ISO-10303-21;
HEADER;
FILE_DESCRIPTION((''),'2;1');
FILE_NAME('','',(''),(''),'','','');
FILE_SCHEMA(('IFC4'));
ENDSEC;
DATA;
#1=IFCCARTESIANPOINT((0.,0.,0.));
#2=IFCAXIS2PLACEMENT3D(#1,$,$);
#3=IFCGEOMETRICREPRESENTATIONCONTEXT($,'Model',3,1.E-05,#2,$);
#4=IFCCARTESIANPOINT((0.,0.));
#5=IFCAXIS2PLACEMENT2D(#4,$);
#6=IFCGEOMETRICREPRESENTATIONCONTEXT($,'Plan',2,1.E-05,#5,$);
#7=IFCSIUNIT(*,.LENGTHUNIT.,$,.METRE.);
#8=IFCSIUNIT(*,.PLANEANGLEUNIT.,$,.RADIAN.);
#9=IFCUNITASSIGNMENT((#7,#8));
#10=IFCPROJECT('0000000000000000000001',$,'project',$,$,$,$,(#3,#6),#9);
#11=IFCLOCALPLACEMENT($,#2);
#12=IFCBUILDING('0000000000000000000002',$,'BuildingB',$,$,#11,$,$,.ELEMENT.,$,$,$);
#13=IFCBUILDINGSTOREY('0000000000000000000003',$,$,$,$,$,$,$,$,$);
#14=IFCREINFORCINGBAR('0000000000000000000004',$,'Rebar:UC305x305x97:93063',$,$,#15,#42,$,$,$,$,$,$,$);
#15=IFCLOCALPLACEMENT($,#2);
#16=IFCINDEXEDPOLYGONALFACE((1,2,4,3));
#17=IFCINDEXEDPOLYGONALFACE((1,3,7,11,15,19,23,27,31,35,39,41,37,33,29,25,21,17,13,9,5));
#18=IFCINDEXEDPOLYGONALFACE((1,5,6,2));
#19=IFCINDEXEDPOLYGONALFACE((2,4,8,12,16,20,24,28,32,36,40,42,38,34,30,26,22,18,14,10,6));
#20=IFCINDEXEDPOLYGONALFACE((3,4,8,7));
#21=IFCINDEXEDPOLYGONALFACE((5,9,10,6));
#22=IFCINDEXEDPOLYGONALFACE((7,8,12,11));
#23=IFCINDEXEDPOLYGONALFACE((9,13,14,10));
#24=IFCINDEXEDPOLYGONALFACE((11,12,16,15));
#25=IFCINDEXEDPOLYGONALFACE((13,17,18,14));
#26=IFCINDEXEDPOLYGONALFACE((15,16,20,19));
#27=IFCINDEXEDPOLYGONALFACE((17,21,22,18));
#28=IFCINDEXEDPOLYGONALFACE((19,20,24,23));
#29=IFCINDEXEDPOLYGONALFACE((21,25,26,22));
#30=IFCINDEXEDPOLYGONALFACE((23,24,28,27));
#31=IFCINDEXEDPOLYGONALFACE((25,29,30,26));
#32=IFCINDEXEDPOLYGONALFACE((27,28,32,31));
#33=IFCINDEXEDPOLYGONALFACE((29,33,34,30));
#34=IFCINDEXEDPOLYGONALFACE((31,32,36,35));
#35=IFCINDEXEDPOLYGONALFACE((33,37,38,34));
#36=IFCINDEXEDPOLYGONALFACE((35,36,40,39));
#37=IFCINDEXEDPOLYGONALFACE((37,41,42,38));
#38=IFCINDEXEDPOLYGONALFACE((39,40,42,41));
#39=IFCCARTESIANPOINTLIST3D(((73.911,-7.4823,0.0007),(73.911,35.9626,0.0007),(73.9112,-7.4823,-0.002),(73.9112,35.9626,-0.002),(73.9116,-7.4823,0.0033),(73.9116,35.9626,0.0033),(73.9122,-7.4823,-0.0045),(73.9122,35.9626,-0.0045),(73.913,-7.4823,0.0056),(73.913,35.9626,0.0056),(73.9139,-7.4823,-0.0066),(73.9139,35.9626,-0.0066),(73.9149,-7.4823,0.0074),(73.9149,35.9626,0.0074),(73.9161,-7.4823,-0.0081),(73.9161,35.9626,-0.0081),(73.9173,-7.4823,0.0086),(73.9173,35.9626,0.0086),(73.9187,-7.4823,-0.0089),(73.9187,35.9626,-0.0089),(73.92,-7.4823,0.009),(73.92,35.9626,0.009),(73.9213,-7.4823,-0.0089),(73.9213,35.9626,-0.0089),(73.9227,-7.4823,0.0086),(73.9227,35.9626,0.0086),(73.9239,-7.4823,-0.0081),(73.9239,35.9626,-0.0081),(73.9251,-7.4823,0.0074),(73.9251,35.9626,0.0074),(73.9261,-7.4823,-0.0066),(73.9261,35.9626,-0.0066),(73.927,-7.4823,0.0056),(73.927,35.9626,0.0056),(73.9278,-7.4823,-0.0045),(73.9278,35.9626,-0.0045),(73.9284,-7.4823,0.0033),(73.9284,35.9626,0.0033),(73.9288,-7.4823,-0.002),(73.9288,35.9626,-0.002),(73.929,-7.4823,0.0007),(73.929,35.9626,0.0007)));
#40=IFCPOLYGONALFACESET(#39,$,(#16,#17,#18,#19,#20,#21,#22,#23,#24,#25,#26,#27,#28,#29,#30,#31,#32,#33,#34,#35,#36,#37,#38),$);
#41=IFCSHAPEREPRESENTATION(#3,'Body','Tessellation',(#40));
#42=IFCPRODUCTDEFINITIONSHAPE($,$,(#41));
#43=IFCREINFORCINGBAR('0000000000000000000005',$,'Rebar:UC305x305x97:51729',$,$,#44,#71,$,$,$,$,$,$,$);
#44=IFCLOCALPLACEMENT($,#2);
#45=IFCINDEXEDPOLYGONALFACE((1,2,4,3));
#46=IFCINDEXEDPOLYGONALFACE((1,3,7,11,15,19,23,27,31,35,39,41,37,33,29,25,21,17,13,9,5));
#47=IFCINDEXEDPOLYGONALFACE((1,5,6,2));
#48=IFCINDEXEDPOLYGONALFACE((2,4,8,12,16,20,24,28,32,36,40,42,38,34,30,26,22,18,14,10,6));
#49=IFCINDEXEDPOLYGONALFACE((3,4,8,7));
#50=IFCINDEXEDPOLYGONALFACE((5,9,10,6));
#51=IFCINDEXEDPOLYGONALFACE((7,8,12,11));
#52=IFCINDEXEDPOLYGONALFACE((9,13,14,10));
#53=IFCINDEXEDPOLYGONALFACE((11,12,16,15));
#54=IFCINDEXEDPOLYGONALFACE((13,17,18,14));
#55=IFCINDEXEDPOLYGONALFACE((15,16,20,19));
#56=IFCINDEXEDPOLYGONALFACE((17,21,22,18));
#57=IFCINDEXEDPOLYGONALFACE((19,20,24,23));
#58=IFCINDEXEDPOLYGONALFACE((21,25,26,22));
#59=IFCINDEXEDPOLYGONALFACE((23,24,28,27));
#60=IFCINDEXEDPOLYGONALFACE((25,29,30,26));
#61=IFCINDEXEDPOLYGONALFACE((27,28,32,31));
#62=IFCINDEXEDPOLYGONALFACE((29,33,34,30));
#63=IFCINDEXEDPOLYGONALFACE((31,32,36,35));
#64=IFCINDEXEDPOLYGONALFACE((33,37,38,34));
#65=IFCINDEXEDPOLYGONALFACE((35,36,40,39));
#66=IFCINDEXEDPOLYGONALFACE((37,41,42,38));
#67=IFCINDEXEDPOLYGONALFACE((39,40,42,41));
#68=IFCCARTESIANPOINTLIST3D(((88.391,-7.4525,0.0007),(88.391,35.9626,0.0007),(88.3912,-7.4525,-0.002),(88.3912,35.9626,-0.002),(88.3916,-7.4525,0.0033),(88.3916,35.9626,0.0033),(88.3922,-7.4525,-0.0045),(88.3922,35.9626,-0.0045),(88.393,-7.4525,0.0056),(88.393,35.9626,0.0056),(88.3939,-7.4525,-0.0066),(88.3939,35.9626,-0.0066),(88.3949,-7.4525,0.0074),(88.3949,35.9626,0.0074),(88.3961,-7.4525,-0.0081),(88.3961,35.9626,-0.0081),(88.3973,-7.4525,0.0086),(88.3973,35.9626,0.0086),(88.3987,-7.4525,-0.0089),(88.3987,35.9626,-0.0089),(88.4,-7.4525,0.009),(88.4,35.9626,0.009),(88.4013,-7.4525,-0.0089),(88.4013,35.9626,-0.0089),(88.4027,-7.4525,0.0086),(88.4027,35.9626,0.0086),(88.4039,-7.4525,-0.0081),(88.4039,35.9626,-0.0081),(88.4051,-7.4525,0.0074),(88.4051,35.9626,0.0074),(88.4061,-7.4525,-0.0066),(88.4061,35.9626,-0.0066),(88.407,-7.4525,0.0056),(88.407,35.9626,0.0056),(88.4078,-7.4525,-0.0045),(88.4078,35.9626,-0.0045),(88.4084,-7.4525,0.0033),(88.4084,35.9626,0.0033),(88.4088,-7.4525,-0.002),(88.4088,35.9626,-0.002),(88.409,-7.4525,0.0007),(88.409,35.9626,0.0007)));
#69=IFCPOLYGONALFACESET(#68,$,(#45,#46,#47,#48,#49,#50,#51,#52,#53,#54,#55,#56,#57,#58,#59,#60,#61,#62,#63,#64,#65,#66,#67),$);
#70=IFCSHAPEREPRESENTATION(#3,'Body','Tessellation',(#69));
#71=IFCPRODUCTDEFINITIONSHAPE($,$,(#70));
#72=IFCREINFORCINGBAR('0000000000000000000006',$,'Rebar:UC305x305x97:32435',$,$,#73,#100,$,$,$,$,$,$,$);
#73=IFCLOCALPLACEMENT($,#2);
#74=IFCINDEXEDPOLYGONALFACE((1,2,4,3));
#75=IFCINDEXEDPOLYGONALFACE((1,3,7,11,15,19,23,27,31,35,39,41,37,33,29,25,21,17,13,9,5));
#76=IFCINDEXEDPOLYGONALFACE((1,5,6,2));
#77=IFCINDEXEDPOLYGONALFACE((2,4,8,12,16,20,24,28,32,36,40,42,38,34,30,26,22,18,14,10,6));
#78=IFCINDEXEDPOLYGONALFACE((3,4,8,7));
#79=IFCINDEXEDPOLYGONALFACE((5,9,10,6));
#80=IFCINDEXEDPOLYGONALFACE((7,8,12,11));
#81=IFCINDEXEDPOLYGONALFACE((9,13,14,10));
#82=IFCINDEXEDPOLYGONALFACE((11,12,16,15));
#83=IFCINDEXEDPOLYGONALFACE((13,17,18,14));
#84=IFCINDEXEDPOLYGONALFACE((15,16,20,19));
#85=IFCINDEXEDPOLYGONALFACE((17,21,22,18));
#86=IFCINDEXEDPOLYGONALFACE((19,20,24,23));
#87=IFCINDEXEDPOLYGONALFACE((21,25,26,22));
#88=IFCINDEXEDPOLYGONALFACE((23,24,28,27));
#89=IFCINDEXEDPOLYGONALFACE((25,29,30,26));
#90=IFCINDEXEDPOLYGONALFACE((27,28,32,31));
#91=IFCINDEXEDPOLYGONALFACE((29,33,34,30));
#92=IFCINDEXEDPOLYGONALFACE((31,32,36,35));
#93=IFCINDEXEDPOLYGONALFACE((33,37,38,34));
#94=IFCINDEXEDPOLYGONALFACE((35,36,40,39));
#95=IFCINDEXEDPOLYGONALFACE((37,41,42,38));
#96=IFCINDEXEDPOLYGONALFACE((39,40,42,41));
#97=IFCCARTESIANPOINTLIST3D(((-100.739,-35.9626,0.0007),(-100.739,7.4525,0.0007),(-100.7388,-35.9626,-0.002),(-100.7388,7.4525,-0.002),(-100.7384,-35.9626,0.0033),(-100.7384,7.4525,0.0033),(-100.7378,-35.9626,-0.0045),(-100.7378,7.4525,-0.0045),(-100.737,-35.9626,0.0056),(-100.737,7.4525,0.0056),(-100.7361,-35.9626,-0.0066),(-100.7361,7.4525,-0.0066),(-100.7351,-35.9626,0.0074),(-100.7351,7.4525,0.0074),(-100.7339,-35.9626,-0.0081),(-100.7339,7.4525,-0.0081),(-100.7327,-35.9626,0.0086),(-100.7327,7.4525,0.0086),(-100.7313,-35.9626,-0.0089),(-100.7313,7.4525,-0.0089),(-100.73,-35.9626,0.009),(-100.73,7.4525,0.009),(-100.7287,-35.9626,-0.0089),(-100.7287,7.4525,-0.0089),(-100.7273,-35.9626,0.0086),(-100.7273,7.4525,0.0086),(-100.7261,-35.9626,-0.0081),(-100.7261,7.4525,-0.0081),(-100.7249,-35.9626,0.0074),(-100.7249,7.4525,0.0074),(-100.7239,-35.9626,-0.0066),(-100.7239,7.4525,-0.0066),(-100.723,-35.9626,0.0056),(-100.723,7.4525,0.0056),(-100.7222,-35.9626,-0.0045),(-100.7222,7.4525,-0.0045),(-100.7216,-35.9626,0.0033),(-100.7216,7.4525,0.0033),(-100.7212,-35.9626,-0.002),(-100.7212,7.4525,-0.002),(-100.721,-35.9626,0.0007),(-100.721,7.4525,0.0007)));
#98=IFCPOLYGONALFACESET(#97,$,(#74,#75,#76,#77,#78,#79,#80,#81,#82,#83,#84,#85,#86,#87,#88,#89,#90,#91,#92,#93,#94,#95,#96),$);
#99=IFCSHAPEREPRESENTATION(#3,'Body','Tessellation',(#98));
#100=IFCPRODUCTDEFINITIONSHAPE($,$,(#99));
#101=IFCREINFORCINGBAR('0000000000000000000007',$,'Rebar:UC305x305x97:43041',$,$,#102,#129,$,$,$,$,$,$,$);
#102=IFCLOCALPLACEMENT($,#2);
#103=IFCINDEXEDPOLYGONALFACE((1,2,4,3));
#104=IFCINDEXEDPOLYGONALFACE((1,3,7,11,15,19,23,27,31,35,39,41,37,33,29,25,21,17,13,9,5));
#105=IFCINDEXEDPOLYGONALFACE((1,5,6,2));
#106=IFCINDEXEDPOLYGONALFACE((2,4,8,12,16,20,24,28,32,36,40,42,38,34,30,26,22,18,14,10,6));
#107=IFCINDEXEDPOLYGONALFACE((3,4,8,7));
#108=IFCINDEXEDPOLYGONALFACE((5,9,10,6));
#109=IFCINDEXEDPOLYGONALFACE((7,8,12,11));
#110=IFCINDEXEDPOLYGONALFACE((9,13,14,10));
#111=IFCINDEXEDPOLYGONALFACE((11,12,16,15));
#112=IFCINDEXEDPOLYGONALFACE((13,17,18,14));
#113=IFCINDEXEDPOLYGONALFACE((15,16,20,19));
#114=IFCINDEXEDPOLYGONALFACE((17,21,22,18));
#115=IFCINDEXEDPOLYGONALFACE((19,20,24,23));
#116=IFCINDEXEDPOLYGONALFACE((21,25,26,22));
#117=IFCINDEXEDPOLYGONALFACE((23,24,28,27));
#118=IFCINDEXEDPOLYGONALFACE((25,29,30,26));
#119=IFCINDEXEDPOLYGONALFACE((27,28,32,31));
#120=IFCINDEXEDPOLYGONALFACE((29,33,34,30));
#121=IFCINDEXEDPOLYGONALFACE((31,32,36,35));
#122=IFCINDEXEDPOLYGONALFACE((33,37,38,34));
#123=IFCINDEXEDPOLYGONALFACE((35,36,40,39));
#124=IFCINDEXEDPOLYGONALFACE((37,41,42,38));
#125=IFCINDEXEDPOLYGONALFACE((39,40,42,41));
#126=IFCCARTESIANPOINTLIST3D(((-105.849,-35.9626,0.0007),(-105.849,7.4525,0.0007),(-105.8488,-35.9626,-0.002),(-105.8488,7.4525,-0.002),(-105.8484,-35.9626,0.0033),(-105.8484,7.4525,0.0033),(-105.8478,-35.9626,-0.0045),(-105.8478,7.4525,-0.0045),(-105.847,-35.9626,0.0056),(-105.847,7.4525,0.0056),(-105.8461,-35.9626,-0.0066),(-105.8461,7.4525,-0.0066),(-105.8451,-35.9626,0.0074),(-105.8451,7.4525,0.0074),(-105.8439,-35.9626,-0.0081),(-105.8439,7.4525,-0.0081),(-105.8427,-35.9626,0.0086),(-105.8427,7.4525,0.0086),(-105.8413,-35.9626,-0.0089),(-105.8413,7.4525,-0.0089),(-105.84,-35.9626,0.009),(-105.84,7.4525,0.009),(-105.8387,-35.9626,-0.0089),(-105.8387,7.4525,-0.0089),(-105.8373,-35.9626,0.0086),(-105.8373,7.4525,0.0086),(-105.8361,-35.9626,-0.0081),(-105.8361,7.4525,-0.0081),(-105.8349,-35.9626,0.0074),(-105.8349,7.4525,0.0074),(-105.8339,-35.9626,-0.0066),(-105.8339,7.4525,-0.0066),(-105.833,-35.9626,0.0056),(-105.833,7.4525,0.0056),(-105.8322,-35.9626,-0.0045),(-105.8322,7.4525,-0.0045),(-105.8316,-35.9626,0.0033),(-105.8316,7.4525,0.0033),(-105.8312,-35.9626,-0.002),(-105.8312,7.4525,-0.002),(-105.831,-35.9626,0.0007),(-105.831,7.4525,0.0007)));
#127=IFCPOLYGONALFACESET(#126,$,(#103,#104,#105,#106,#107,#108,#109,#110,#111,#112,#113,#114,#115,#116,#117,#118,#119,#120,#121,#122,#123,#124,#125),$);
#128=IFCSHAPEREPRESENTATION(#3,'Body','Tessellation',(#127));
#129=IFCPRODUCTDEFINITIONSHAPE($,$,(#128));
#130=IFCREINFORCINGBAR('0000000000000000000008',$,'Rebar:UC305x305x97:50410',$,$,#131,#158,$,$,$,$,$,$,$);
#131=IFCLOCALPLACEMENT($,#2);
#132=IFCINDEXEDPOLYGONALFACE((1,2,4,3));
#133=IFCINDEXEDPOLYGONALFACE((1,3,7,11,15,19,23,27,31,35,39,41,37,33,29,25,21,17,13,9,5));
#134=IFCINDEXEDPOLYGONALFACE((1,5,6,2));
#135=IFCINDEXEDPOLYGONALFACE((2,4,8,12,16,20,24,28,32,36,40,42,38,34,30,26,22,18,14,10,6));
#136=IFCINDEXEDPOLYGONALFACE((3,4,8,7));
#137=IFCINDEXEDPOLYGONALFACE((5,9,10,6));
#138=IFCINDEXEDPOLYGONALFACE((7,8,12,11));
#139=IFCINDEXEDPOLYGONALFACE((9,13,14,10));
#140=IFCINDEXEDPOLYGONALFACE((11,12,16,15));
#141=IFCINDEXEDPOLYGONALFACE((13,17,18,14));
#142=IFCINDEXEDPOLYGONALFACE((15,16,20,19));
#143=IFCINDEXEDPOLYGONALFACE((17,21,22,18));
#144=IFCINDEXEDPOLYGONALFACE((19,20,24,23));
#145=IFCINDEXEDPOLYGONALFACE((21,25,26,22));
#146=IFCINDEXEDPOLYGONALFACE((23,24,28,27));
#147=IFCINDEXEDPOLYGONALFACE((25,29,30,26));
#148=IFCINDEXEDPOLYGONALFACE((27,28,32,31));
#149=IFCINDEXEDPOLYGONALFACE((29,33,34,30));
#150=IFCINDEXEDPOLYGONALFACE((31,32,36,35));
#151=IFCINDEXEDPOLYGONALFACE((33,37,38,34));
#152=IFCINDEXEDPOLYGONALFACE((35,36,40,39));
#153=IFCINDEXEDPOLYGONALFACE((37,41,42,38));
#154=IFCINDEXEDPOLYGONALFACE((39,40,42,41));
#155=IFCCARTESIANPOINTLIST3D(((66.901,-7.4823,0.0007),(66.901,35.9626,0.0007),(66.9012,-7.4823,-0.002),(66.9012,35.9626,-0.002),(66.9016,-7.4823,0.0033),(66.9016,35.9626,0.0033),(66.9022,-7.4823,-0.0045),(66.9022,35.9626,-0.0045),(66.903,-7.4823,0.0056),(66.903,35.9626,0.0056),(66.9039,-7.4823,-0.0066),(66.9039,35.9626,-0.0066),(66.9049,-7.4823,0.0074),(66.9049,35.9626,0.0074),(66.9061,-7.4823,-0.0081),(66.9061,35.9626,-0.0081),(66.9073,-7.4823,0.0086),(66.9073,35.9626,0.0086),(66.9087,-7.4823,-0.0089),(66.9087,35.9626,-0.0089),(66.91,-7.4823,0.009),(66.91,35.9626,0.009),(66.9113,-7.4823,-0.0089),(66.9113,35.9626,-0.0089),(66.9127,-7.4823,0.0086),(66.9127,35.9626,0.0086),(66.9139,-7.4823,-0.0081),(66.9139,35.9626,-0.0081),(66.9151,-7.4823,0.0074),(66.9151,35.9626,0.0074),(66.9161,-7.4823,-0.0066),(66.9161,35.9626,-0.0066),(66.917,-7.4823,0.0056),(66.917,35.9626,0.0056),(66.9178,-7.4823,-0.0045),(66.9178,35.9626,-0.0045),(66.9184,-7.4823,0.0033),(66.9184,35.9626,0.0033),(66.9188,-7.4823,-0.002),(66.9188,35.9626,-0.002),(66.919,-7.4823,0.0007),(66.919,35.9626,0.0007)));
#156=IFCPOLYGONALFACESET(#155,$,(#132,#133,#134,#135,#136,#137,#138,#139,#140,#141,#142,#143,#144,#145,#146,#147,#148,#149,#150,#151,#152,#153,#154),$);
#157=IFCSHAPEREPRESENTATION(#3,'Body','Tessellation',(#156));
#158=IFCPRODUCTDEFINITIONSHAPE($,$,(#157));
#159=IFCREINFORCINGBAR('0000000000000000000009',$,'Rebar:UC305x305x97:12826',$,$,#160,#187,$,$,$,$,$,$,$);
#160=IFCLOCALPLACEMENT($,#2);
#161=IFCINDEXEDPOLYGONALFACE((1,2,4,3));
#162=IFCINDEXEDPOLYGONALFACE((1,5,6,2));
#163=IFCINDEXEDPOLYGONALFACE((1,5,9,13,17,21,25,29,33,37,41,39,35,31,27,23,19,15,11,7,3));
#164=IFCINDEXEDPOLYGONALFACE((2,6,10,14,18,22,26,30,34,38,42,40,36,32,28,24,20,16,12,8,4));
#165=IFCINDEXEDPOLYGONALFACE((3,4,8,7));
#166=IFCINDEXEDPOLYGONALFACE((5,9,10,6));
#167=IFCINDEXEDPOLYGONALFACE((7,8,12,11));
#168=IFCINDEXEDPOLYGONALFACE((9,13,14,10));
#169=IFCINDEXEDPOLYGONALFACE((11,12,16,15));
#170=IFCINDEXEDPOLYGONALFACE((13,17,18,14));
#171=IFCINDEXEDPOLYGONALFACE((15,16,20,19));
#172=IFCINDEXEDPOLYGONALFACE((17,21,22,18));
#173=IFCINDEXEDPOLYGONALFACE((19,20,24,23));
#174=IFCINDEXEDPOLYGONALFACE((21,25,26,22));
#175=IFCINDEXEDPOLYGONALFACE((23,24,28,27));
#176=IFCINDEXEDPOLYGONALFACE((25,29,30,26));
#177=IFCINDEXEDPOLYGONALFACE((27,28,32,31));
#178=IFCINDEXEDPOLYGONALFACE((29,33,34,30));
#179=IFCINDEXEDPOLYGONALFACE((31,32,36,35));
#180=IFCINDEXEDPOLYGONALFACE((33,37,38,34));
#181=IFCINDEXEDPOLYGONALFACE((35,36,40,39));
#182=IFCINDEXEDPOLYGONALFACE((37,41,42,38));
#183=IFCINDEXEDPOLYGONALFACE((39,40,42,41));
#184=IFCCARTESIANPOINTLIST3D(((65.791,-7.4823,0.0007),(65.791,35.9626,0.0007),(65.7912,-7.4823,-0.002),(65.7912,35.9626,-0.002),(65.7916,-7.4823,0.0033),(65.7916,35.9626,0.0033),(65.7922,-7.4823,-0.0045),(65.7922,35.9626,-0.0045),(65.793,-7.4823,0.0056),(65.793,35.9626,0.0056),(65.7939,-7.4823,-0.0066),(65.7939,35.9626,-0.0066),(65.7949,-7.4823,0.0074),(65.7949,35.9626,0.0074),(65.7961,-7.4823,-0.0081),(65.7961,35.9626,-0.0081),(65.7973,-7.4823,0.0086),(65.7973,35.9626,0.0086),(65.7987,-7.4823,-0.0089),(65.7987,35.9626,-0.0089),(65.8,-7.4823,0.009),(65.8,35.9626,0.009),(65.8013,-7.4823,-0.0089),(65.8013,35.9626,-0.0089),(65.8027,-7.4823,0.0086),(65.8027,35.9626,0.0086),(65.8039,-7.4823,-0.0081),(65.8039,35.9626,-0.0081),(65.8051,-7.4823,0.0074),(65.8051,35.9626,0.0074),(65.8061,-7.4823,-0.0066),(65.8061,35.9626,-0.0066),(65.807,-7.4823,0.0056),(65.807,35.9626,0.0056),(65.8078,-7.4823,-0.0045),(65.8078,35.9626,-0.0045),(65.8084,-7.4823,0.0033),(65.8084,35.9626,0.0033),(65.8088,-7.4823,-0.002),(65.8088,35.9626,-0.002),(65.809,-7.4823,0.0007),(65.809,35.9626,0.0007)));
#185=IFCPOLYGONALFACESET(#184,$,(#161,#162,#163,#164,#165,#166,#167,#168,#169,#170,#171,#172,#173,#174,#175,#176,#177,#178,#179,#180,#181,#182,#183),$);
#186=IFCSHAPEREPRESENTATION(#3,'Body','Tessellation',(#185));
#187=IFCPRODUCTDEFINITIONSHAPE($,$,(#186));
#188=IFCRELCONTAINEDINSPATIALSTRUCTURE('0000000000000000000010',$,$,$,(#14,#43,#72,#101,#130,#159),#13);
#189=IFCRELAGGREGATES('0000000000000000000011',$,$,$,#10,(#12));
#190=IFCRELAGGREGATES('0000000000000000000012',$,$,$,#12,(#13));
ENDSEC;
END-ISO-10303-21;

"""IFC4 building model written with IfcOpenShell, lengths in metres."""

from ifc_helpers import new_model, entity, si_unit, origin, origin_2d, place, context, project, spatial, element, save


model = new_model("IFC4")

# Units and contexts
model_context = context("Model", 3, precision=1e-05, world=origin())
plan_context = context("Plan", 2, precision=1e-05, world=origin_2d())
ifc_project = project(units=[si_unit("LENGTHUNIT", "METRE"), si_unit("PLANEANGLEUNIT", "RADIAN")], contexts=[model_context, plan_context])

# Building, storey
building_placement = place(None, origin())
building = spatial("IfcBuilding", under=ifc_project, at=building_placement, Name="BuildingB", CompositionType="ELEMENT")
storey = spatial("IfcBuildingStorey", under=building)

# Reinforcing bars
element("IfcReinforcingBar", 1, inside=storey, Name="Rebar:UC305x305x97:93063", context=model_context, shape_type="SweptSolid", body=[
    entity("IfcSurfaceCurveSweptAreaSolid", entity("IfcCircleProfileDef", "AREA", None, None, 0.009), None, entity("IfcPolyline", [entity("IfcCartesianPoint", [73.92, 35.9626, 0.0]), entity("IfcCartesianPoint", [73.92, -7.4823, 0.0])]), None, None, entity("IfcPlane", entity("IfcAxis2Placement3D", entity("IfcCartesianPoint", [73.92, 35.9626, 0.0]), entity("IfcDirection", [0.0, 0.0, 1.0]), entity("IfcDirection", [1.0, 0.0, 0.0])))),
])
element("IfcReinforcingBar", 2, inside=storey, Name="Rebar:UC305x305x97:51729", context=model_context, shape_type="SweptSolid", body=[
    entity("IfcSurfaceCurveSweptAreaSolid", entity("IfcCircleProfileDef", "AREA", None, None, 0.009), None, entity("IfcPolyline", [entity("IfcCartesianPoint", [88.4, 35.9626, 0.0]), entity("IfcCartesianPoint", [88.4, -7.4525, 0.0])]), None, None, entity("IfcPlane", entity("IfcAxis2Placement3D", entity("IfcCartesianPoint", [88.4, 35.9626, 0.0]), entity("IfcDirection", [0.0, 0.0, 1.0]), entity("IfcDirection", [1.0, 0.0, 0.0])))),
])
element("IfcReinforcingBar", 3, inside=storey, Name="Rebar:UC305x305x97:32435", context=model_context, shape_type="SweptSolid", body=[
    entity("IfcSurfaceCurveSweptAreaSolid", entity("IfcCircleProfileDef", "AREA", None, None, 0.009), None, entity("IfcPolyline", [entity("IfcCartesianPoint", [100.73, 35.9626, 0.0]), entity("IfcCartesianPoint", [100.73, -7.4525, 0.0])]), None, None, entity("IfcPlane", entity("IfcAxis2Placement3D", entity("IfcCartesianPoint", [100.73, 35.9626, 0.0]), entity("IfcDirection", [0.0, 0.0, 1.0]), entity("IfcDirection", [1.0, 0.0, 0.0])))),
])
element("IfcReinforcingBar", 4, inside=storey, Name="Rebar:UC305x305x97:43041", context=model_context, shape_type="SweptSolid", body=[
    entity("IfcSurfaceCurveSweptAreaSolid", entity("IfcCircleProfileDef", "AREA", None, None, 0.009), None, entity("IfcPolyline", [entity("IfcCartesianPoint", [105.84, 35.9626, 0.0]), entity("IfcCartesianPoint", [105.84, -7.4525, 0.0])]), None, None, entity("IfcPlane", entity("IfcAxis2Placement3D", entity("IfcCartesianPoint", [105.84, 35.9626, 0.0]), entity("IfcDirection", [0.0, 0.0, 1.0]), entity("IfcDirection", [1.0, 0.0, 0.0])))),
])
element("IfcReinforcingBar", 5, inside=storey, Name="Rebar:UC305x305x97:50410", context=model_context, shape_type="SweptSolid", body=[
    entity("IfcSurfaceCurveSweptAreaSolid", entity("IfcCircleProfileDef", "AREA", None, None, 0.009), None, entity("IfcPolyline", [entity("IfcCartesianPoint", [66.91, 35.9626, 0.0]), entity("IfcCartesianPoint", [66.91, -7.4823, 0.0])]), None, None, entity("IfcPlane", entity("IfcAxis2Placement3D", entity("IfcCartesianPoint", [66.91, 35.9626, 0.0]), entity("IfcDirection", [0.0, 0.0, 1.0]), entity("IfcDirection", [1.0, 0.0, 0.0])))),
])
element("IfcReinforcingBar", 6, inside=storey, Name="Rebar:UC305x305x97:12826", context=model_context, shape_type="SweptSolid", body=[
    entity("IfcSurfaceCurveSweptAreaSolid", entity("IfcCircleProfileDef", "AREA", None, None, 0.009), None, entity("IfcPolyline", [entity("IfcCartesianPoint", [65.8, -7.4823, 0.0]), entity("IfcCartesianPoint", [65.8, 35.9626, 0.0])]), None, None, entity("IfcPlane", entity("IfcAxis2Placement3D", entity("IfcCartesianPoint", [65.8, -7.4823, 0.0]), entity("IfcDirection", [0.0, 0.0, 1.0]), entity("IfcDirection", [1.0, 0.0, 0.0])))),
])

save(model, "model.ifc")
